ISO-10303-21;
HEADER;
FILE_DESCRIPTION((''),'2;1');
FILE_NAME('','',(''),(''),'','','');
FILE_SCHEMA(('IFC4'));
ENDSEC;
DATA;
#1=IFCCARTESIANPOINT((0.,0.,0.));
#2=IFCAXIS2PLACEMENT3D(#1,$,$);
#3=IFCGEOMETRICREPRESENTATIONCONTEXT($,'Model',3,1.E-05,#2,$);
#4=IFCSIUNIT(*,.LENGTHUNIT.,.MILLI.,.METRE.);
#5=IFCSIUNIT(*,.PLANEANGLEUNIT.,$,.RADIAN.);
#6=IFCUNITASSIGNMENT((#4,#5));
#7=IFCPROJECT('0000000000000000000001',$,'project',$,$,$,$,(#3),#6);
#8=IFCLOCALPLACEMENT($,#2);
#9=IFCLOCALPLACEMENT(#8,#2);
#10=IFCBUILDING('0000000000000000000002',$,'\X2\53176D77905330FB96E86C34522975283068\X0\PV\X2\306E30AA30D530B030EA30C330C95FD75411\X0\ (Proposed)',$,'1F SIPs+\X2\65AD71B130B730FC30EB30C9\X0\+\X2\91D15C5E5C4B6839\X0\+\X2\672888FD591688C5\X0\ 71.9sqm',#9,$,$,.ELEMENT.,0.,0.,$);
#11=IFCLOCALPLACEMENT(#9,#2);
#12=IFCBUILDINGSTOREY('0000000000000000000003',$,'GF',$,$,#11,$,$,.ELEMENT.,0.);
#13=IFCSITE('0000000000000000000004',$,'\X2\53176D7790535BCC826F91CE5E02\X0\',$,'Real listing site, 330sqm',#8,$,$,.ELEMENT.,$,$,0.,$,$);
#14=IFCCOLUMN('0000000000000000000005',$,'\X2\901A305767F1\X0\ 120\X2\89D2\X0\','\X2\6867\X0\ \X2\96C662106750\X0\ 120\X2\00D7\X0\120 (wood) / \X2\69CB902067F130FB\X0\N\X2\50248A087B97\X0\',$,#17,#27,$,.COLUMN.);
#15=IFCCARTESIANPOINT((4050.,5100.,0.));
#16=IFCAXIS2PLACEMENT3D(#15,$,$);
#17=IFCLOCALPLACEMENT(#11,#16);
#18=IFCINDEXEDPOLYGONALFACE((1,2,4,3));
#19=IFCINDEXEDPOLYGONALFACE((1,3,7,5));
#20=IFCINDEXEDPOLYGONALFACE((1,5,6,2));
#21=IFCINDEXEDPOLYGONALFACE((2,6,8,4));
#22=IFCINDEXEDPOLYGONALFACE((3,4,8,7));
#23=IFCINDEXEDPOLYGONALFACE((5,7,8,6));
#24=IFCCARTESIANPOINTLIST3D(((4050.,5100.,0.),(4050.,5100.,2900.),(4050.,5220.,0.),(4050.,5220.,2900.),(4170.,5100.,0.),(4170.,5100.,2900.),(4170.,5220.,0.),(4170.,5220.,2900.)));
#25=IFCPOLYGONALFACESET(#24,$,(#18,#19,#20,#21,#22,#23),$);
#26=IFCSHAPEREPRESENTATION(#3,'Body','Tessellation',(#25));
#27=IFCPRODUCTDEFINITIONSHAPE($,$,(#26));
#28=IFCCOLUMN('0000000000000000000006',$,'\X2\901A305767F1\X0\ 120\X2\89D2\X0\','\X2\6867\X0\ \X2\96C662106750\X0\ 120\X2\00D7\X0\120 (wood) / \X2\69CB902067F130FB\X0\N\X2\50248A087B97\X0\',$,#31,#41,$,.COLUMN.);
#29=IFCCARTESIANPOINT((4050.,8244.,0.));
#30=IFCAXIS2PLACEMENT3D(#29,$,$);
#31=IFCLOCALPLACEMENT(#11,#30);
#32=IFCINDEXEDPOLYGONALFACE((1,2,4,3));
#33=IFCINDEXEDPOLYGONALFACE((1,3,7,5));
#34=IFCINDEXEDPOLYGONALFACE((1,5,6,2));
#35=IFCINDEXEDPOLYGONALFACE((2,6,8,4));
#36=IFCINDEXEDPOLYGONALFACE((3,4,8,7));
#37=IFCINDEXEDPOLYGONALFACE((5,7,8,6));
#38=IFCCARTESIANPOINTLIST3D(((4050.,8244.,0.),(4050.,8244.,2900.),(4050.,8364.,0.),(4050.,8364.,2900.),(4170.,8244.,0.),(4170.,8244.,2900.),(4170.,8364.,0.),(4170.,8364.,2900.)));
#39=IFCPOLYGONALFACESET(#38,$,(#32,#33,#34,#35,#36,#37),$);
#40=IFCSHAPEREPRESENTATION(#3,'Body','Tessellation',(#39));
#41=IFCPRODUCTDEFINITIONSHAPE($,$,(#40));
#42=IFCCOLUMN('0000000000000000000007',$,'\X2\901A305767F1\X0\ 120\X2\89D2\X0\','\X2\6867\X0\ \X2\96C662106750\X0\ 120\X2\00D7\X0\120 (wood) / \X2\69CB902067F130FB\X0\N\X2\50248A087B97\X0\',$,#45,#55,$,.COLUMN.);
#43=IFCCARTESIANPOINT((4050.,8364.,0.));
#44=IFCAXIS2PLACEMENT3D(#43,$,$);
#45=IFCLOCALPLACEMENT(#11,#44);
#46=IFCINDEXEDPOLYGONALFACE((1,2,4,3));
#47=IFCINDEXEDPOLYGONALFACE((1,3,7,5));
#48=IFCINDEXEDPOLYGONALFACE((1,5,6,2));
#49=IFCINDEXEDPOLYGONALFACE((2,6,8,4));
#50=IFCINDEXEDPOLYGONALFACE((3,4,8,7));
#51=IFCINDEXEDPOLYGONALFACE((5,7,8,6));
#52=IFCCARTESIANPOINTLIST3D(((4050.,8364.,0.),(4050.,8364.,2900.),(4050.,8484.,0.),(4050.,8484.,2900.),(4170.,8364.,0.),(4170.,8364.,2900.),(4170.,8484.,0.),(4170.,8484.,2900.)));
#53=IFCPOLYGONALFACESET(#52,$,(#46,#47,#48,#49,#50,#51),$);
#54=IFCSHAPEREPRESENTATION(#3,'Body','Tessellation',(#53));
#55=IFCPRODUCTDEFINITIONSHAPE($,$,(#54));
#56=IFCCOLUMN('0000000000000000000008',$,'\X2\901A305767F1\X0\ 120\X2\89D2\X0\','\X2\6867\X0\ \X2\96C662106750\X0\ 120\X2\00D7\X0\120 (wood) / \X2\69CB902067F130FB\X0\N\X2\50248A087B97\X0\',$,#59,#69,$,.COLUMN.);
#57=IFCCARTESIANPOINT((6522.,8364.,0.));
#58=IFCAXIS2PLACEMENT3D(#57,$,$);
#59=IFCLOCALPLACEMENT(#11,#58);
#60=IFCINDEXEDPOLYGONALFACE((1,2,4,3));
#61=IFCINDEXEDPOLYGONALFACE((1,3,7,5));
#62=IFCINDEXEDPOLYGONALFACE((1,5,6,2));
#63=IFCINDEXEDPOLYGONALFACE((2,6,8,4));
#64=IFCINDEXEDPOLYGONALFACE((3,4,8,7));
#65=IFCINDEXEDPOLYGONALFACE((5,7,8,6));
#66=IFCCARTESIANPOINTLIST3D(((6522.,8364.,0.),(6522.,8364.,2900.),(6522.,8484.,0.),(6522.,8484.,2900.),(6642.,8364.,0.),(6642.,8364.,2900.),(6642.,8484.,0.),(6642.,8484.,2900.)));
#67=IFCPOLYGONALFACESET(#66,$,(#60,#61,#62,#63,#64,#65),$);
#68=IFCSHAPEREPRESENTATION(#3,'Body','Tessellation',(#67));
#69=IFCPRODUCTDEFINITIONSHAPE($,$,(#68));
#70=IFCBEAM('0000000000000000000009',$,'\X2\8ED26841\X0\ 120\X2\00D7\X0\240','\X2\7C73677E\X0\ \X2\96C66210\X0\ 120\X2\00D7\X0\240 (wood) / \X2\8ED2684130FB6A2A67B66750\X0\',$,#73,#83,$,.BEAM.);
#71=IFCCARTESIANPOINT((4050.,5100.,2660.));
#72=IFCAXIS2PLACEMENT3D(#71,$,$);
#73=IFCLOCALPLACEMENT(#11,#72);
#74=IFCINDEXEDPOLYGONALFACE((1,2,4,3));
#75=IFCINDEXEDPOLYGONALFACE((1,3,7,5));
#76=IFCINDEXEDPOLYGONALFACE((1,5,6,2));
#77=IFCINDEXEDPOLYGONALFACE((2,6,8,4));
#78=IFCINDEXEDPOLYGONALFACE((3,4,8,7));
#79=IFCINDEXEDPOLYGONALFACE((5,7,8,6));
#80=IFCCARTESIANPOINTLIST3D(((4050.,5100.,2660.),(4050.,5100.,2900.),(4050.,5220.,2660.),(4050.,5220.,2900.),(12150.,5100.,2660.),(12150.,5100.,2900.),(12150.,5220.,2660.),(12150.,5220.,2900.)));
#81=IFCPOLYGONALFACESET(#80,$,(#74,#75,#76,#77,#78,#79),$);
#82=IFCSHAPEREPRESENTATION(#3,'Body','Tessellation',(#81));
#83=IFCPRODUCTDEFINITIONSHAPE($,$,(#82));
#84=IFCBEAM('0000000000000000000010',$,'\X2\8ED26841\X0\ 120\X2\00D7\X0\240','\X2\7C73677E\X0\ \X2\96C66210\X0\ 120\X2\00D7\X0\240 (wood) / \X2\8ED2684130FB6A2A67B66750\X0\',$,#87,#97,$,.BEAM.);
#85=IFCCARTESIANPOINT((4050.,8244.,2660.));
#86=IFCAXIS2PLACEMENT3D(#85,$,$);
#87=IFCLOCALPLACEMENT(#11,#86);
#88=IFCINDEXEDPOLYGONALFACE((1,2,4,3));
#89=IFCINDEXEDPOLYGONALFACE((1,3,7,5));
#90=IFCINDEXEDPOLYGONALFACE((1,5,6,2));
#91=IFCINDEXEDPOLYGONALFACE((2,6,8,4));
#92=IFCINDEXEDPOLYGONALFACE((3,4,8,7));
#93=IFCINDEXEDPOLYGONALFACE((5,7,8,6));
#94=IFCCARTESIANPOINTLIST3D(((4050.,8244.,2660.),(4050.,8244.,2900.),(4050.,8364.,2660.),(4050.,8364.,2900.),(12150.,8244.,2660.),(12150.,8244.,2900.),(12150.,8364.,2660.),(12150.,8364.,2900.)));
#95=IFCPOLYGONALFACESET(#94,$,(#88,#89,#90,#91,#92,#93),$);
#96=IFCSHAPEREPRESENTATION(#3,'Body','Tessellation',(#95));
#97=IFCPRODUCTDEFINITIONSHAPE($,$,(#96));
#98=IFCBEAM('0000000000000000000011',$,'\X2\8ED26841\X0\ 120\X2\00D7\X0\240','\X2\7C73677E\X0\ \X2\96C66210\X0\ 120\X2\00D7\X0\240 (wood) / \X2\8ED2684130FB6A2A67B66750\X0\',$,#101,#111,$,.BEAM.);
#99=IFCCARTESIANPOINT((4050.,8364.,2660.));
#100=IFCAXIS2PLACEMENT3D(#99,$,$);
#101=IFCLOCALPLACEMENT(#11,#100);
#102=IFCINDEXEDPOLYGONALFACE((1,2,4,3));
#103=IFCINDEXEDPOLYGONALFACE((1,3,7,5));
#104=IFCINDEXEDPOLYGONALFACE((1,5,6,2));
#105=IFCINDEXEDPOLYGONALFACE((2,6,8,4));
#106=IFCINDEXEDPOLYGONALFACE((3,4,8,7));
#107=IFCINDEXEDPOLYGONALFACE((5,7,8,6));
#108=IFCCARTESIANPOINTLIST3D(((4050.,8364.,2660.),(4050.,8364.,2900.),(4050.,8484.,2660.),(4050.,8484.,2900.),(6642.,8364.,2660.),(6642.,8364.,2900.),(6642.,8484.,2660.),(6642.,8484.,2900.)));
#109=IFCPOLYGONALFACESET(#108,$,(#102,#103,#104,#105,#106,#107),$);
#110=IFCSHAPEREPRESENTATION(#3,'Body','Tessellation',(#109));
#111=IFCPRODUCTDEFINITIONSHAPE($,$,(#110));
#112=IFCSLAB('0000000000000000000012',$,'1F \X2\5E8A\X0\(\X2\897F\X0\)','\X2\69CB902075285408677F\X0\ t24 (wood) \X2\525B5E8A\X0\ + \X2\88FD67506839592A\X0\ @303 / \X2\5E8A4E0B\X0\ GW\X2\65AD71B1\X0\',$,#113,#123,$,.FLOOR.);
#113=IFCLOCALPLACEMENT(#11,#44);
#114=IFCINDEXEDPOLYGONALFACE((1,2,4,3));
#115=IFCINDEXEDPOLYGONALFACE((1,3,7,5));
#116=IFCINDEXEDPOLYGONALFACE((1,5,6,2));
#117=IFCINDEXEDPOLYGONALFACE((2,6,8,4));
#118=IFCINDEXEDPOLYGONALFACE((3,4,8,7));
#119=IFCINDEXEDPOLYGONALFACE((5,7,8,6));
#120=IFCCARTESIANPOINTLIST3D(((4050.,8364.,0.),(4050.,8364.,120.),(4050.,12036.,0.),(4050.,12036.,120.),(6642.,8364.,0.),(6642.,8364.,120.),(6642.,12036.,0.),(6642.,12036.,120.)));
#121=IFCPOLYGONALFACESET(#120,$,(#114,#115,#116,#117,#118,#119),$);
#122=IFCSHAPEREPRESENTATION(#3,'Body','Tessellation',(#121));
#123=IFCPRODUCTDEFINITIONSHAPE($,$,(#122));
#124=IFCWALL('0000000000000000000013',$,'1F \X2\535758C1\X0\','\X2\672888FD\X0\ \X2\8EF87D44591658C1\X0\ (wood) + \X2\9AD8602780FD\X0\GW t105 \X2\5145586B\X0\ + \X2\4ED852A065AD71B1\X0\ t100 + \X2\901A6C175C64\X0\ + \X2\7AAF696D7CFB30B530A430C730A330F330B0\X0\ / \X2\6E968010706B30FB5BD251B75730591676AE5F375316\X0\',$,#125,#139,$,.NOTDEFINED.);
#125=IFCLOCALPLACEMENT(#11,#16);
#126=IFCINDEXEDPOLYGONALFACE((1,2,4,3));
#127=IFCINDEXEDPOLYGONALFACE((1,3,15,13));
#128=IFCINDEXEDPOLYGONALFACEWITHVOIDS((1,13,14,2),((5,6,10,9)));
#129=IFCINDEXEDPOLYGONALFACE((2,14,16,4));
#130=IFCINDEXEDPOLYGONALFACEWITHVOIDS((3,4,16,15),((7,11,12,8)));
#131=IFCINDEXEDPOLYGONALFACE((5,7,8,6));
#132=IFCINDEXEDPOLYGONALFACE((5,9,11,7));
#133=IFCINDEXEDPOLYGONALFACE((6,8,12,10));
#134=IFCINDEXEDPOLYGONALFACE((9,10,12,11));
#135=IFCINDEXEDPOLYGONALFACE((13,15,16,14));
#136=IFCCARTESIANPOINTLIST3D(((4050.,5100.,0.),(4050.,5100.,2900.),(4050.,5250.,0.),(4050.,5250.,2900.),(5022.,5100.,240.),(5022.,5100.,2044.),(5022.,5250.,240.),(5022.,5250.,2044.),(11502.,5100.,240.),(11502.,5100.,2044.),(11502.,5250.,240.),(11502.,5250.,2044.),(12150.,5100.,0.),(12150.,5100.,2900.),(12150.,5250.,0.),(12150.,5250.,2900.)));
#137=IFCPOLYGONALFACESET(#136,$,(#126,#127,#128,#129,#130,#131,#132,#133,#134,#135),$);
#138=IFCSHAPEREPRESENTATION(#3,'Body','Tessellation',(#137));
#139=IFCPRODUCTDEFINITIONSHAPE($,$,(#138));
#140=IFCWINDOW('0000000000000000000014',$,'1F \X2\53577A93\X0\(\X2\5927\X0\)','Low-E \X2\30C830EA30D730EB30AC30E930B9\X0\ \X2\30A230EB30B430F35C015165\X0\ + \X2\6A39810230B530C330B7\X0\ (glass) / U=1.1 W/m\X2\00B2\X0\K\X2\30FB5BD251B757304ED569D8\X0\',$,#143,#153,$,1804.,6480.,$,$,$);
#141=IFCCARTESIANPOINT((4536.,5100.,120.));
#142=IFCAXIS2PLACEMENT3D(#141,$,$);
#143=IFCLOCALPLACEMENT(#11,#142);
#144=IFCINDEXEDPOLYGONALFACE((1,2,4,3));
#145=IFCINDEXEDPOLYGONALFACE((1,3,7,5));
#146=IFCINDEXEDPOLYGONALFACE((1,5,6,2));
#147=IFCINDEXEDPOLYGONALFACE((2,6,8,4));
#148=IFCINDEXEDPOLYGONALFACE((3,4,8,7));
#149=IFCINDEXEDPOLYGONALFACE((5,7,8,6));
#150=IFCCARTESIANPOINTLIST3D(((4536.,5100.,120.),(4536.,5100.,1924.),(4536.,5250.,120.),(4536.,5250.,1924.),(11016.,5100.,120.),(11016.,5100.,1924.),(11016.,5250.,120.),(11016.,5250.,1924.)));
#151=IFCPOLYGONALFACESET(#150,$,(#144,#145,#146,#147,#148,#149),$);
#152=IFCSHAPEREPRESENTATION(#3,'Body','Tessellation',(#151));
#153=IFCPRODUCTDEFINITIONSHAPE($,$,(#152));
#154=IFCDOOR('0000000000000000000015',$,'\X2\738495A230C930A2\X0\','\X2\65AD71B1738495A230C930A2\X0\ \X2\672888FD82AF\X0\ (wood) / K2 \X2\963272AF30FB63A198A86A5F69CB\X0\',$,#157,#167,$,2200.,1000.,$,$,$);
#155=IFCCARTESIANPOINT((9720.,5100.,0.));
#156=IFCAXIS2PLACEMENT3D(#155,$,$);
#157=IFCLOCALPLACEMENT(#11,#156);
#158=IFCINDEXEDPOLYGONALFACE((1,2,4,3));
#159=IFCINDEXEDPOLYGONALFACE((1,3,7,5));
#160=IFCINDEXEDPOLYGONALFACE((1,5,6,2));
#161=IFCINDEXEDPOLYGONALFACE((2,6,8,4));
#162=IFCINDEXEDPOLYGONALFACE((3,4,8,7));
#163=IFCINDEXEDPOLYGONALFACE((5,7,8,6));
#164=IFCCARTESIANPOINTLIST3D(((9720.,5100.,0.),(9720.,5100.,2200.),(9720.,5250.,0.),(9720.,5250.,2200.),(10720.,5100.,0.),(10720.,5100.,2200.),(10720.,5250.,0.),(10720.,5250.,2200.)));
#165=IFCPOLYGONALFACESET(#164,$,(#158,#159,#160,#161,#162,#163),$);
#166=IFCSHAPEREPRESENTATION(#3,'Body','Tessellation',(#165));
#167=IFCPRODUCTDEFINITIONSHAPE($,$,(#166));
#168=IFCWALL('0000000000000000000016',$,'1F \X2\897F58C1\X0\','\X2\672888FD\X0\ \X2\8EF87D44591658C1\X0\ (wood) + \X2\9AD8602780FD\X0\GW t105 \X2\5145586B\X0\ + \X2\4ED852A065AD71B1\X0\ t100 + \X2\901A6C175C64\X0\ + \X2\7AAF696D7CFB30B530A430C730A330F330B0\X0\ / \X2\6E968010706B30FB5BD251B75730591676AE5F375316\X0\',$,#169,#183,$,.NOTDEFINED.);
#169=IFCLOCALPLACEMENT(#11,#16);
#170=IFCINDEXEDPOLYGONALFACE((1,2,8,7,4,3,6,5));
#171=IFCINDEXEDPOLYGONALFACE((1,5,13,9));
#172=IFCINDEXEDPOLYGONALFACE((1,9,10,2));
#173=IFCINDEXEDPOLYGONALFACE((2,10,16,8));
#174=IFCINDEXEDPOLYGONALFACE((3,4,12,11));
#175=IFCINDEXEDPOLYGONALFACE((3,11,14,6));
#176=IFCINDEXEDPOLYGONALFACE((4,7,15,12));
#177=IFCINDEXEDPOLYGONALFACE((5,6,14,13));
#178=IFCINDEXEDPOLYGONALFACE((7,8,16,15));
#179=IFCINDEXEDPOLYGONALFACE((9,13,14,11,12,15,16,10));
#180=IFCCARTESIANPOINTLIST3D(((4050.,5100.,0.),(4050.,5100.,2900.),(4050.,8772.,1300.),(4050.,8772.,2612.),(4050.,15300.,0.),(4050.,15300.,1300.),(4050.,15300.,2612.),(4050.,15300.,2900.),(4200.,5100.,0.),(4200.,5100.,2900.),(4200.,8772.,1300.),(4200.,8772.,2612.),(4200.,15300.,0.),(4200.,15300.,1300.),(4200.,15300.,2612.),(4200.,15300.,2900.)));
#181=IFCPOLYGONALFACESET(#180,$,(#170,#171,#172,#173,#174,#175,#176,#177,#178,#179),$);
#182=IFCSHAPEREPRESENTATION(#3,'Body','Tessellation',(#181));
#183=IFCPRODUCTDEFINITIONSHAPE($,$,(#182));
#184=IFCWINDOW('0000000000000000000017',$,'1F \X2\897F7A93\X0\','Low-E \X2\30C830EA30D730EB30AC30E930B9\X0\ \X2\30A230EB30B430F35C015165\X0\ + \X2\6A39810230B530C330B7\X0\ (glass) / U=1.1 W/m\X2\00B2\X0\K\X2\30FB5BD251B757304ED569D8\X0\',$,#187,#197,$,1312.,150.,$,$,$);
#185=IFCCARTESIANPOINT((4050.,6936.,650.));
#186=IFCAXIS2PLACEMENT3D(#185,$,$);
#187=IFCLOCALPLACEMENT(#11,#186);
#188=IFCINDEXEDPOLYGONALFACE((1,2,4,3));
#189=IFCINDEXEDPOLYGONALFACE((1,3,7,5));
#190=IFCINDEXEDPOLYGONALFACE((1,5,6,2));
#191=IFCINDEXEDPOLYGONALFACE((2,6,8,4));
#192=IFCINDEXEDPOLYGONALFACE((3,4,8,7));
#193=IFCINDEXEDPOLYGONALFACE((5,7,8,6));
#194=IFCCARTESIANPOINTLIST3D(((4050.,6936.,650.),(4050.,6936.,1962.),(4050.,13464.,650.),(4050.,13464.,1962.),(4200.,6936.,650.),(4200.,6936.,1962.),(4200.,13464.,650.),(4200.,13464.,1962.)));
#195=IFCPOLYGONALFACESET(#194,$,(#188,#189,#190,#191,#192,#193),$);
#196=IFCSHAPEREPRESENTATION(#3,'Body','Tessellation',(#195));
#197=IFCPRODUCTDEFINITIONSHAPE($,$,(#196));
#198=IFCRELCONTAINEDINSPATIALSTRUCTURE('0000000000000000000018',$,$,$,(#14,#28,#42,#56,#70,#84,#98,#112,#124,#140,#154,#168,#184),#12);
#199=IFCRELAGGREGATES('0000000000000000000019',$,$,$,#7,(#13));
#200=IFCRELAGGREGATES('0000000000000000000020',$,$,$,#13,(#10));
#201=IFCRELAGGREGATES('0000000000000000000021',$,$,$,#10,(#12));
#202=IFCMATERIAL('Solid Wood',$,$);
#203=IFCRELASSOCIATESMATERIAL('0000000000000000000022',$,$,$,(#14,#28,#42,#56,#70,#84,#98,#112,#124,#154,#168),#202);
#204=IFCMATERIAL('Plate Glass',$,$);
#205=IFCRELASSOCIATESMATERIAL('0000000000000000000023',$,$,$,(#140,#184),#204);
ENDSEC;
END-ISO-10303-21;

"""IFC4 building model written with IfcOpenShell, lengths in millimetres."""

from ifc_helpers import new_model, si_unit, frame, frame_2d, origin, place, context, project, spatial, rectangle, extrude, material, element, fill, save


model = new_model("IFC4")

# Units and contexts
model_context = context("Model", 3, precision=1e-05, world=origin())
ifc_project = project(units=[si_unit("LENGTHUNIT", "METRE", prefix="MILLI"), si_unit("PLANEANGLEUNIT", "RADIAN")], contexts=[model_context])

# Site, building, storey
site_placement = place(None, origin())
site = spatial("IfcSite", under=ifc_project, at=site_placement, Name="北海道富良野市", ObjectType="Real listing site, 330sqm", CompositionType="ELEMENT", RefElevation=0.0)
building_placement = place(site_placement, origin())
building = spatial("IfcBuilding", under=site, at=building_placement, Name="北海道・雨水利用とPVのオフグリッド志向 (Proposed)", ObjectType="1F SIPs+断熱シールド+金属屋根+木製外装 71.9sqm", CompositionType="ELEMENT", ElevationOfRefHeight=0.0, ElevationOfTerrain=0.0)
storey_placement = place(building_placement, origin())
storey = spatial("IfcBuildingStorey", under=building, at=storey_placement, Name="GF", CompositionType="ELEMENT", Elevation=0.0)

# Columns
ifc_material_1 = material(Name="Solid Wood")
column_1_placement = place(storey_placement, frame((4050.0, 5100.0, 0.0)))
element("IfcColumn", 1, at=column_1_placement, inside=storey, material=ifc_material_1, Name="通し柱 120角", Description="桧 集成材 120×120 (wood) / 構造柱・N値計算", PredefinedType="COLUMN", context=model_context, shape_type="SweptSolid", body=[
    extrude(rectangle(XDim=120.0, YDim=120.0, at=frame_2d((60.0, 60.0))), frame((4050.0, 5100.0, 0.0)), (0.0, 0.0, 1.0), 2900.0),
])
column_2_placement = place(storey_placement, frame((4050.0, 8244.0, 0.0)))
element("IfcColumn", 2, at=column_2_placement, inside=storey, material=ifc_material_1, Name="通し柱 120角", Description="桧 集成材 120×120 (wood) / 構造柱・N値計算", PredefinedType="COLUMN", context=model_context, shape_type="SweptSolid", body=[
    extrude(rectangle(XDim=120.0, YDim=120.0, at=frame_2d((60.0, 60.0))), frame((4050.0, 8244.0, 0.0)), (0.0, 0.0, 1.0), 2900.0),
])
column_3_placement = place(storey_placement, frame((4050.0, 8364.0, 0.0)))
element("IfcColumn", 3, at=column_3_placement, inside=storey, material=ifc_material_1, Name="通し柱 120角", Description="桧 集成材 120×120 (wood) / 構造柱・N値計算", PredefinedType="COLUMN", context=model_context, shape_type="SweptSolid", body=[
    extrude(rectangle(XDim=120.0, YDim=120.0, at=frame_2d((60.0, 60.0))), frame((4050.0, 8364.0, 0.0)), (0.0, 0.0, 1.0), 2900.0),
])
column_4_placement = place(storey_placement, frame((6522.0, 8364.0, 0.0)))
element("IfcColumn", 4, at=column_4_placement, inside=storey, material=ifc_material_1, Name="通し柱 120角", Description="桧 集成材 120×120 (wood) / 構造柱・N値計算", PredefinedType="COLUMN", context=model_context, shape_type="SweptSolid", body=[
    extrude(rectangle(XDim=120.0, YDim=120.0, at=frame_2d((60.0, 60.0))), frame((6522.0, 8364.0, 0.0)), (0.0, 0.0, 1.0), 2900.0),
])

# Beams
beam_1_placement = place(storey_placement, frame((4050.0, 5100.0, 2660.0)))
element("IfcBeam", 5, at=beam_1_placement, inside=storey, material=ifc_material_1, Name="軒桁 120×240", Description="米松 集成 120×240 (wood) / 軒桁・横架材", PredefinedType="BEAM", context=model_context, shape_type="SweptSolid", body=[
    extrude(rectangle(XDim=8100.0, YDim=120.0, at=frame_2d((4050.0, 60.0))), frame((4050.0, 5100.0, 2660.0)), (0.0, 0.0, 1.0), 240.0),
])
beam_2_placement = place(storey_placement, frame((4050.0, 8244.0, 2660.0)))
element("IfcBeam", 6, at=beam_2_placement, inside=storey, material=ifc_material_1, Name="軒桁 120×240", Description="米松 集成 120×240 (wood) / 軒桁・横架材", PredefinedType="BEAM", context=model_context, shape_type="SweptSolid", body=[
    extrude(rectangle(XDim=8100.0, YDim=120.0, at=frame_2d((4050.0, 60.0))), frame((4050.0, 8244.0, 2660.0)), (0.0, 0.0, 1.0), 240.0),
])
beam_3_placement = place(storey_placement, frame((4050.0, 8364.0, 2660.0)))
element("IfcBeam", 7, at=beam_3_placement, inside=storey, material=ifc_material_1, Name="軒桁 120×240", Description="米松 集成 120×240 (wood) / 軒桁・横架材", PredefinedType="BEAM", context=model_context, shape_type="SweptSolid", body=[
    extrude(rectangle(XDim=2592.0, YDim=120.0, at=frame_2d((1296.0, 60.0))), frame((4050.0, 8364.0, 2660.0)), (0.0, 0.0, 1.0), 240.0),
])

# Slab
slab_1_placement = place(storey_placement, frame((4050.0, 8364.0, 0.0)))
element("IfcSlab", 8, at=slab_1_placement, inside=storey, material=ifc_material_1, Name="1F 床(西)", Description="構造用合板 t24 (wood) 剛床 + 製材根太 @303 / 床下 GW断熱", PredefinedType="FLOOR", context=model_context, shape_type="SweptSolid", body=[
    extrude(rectangle(XDim=2592.0, YDim=3672.0, at=frame_2d((1296.0, 1836.0))), frame((4050.0, 8364.0, 0.0)), (0.0, 0.0, 1.0), 120.0),
])

# Wall, openings, window, door
wall_1_placement = place(storey_placement, frame((4050.0, 5100.0, 0.0)))
wall_1 = element("IfcWall", 9, at=wall_1_placement, inside=storey, material=ifc_material_1, Name="1F 南壁", Description="木製 軸組外壁 (wood) + 高性能GW t105 充填 + 付加断熱 t100 + 通気層 + 窯業系サイディング / 準耐火・寒冷地外皮強化", PredefinedType="NOTDEFINED", context=model_context, shape_type="SweptSolid", body=[
    extrude(rectangle(XDim=8100.0, YDim=150.0, at=frame_2d((4050.0, 75.0))), frame((4050.0, 5100.0, 0.0)), (0.0, 0.0, 1.0), 2900.0),
])
opening_1_placement = place(storey_placement, frame((4536.0, 5100.0, 120.0)))
opening_1 = element("IfcOpeningElement", 10, at=opening_1_placement, cuts=wall_1, PredefinedType="NOTDEFINED", context=model_context, shape_type="SweptSolid", body=[
    extrude(rectangle(XDim=6480.0, YDim=150.0, at=frame_2d((3240.0, 75.0))), frame((4536.0, 5100.0, 120.0)), (0.0, 0.0, 1.0), 1804.0),
])
opening_2_placement = place(storey_placement, frame((9720.0, 5100.0, 0.0)))
opening_2 = element("IfcOpeningElement", 11, at=opening_2_placement, cuts=wall_1, PredefinedType="NOTDEFINED", context=model_context, shape_type="SweptSolid", body=[
    extrude(rectangle(XDim=1000.0, YDim=150.0, at=frame_2d((500.0, 75.0))), frame((9720.0, 5100.0, 0.0)), (0.0, 0.0, 1.0), 2200.0),
])
ifc_material_2 = material(Name="Plate Glass")
window_1_placement = place(storey_placement, frame((4536.0, 5100.0, 120.0)))
window_1 = element("IfcWindow", 12, at=window_1_placement, inside=storey, material=ifc_material_2, Name="1F 南窓(大)", Description="Low-E トリプルガラス アルゴン封入 + 樹脂サッシ (glass) / U=1.1 W/m²K・寒冷地仕様", OverallHeight=1804.0, OverallWidth=6480.0, context=model_context, shape_type="SweptSolid", body=[
    extrude(rectangle(XDim=6480.0, YDim=150.0, at=frame_2d((3240.0, 75.0))), frame((4536.0, 5100.0, 120.0)), (0.0, 0.0, 1.0), 1804.0),
])
fill(opening_1, window_1)
door_placement = place(storey_placement, frame((9720.0, 5100.0, 0.0)))
door = element("IfcDoor", 13, at=door_placement, inside=storey, material=ifc_material_1, Name="玄関ドア", Description="断熱玄関ドア 木製芯 (wood) / K2 防犯・採風機構", OverallHeight=2200.0, OverallWidth=1000.0, context=model_context, shape_type="SweptSolid", body=[
    extrude(rectangle(XDim=1000.0, YDim=150.0, at=frame_2d((500.0, 75.0))), frame((9720.0, 5100.0, 0.0)), (0.0, 0.0, 1.0), 2200.0),
])
fill(opening_2, door)

# Wall, opening, window
wall_2_placement = place(storey_placement, frame((4050.0, 5100.0, 0.0)))
wall_2 = element("IfcWall", 14, at=wall_2_placement, inside=storey, material=ifc_material_1, Name="1F 西壁", Description="木製 軸組外壁 (wood) + 高性能GW t105 充填 + 付加断熱 t100 + 通気層 + 窯業系サイディング / 準耐火・寒冷地外皮強化", PredefinedType="NOTDEFINED", context=model_context, shape_type="SweptSolid", body=[
    extrude(rectangle(XDim=150.0, YDim=10200.0, at=frame_2d((75.0, 5100.0))), frame((4050.0, 5100.0, 0.0)), (0.0, 0.0, 1.0), 2900.0),
])
opening_3_placement = place(storey_placement, frame((4050.0, 6936.0, 650.0)))
opening_3 = element("IfcOpeningElement", 15, at=opening_3_placement, cuts=wall_2, PredefinedType="NOTDEFINED", context=model_context, shape_type="SweptSolid", body=[
    extrude(rectangle(XDim=150.0, YDim=6528.0, at=frame_2d((75.0, 3264.0))), frame((4050.0, 6936.0, 650.0)), (0.0, 0.0, 1.0), 1312.0),
])
window_2_placement = place(storey_placement, frame((4050.0, 6936.0, 650.0)))
window_2 = element("IfcWindow", 16, at=window_2_placement, inside=storey, material=ifc_material_2, Name="1F 西窓", Description="Low-E トリプルガラス アルゴン封入 + 樹脂サッシ (glass) / U=1.1 W/m²K・寒冷地仕様", OverallHeight=1312.0, OverallWidth=150.0, context=model_context, shape_type="SweptSolid", body=[
    extrude(rectangle(XDim=150.0, YDim=6528.0, at=frame_2d((75.0, 3264.0))), frame((4050.0, 6936.0, 650.0)), (0.0, 0.0, 1.0), 1312.0),
])
fill(opening_3, window_2)

save(model, "model.ifc")
